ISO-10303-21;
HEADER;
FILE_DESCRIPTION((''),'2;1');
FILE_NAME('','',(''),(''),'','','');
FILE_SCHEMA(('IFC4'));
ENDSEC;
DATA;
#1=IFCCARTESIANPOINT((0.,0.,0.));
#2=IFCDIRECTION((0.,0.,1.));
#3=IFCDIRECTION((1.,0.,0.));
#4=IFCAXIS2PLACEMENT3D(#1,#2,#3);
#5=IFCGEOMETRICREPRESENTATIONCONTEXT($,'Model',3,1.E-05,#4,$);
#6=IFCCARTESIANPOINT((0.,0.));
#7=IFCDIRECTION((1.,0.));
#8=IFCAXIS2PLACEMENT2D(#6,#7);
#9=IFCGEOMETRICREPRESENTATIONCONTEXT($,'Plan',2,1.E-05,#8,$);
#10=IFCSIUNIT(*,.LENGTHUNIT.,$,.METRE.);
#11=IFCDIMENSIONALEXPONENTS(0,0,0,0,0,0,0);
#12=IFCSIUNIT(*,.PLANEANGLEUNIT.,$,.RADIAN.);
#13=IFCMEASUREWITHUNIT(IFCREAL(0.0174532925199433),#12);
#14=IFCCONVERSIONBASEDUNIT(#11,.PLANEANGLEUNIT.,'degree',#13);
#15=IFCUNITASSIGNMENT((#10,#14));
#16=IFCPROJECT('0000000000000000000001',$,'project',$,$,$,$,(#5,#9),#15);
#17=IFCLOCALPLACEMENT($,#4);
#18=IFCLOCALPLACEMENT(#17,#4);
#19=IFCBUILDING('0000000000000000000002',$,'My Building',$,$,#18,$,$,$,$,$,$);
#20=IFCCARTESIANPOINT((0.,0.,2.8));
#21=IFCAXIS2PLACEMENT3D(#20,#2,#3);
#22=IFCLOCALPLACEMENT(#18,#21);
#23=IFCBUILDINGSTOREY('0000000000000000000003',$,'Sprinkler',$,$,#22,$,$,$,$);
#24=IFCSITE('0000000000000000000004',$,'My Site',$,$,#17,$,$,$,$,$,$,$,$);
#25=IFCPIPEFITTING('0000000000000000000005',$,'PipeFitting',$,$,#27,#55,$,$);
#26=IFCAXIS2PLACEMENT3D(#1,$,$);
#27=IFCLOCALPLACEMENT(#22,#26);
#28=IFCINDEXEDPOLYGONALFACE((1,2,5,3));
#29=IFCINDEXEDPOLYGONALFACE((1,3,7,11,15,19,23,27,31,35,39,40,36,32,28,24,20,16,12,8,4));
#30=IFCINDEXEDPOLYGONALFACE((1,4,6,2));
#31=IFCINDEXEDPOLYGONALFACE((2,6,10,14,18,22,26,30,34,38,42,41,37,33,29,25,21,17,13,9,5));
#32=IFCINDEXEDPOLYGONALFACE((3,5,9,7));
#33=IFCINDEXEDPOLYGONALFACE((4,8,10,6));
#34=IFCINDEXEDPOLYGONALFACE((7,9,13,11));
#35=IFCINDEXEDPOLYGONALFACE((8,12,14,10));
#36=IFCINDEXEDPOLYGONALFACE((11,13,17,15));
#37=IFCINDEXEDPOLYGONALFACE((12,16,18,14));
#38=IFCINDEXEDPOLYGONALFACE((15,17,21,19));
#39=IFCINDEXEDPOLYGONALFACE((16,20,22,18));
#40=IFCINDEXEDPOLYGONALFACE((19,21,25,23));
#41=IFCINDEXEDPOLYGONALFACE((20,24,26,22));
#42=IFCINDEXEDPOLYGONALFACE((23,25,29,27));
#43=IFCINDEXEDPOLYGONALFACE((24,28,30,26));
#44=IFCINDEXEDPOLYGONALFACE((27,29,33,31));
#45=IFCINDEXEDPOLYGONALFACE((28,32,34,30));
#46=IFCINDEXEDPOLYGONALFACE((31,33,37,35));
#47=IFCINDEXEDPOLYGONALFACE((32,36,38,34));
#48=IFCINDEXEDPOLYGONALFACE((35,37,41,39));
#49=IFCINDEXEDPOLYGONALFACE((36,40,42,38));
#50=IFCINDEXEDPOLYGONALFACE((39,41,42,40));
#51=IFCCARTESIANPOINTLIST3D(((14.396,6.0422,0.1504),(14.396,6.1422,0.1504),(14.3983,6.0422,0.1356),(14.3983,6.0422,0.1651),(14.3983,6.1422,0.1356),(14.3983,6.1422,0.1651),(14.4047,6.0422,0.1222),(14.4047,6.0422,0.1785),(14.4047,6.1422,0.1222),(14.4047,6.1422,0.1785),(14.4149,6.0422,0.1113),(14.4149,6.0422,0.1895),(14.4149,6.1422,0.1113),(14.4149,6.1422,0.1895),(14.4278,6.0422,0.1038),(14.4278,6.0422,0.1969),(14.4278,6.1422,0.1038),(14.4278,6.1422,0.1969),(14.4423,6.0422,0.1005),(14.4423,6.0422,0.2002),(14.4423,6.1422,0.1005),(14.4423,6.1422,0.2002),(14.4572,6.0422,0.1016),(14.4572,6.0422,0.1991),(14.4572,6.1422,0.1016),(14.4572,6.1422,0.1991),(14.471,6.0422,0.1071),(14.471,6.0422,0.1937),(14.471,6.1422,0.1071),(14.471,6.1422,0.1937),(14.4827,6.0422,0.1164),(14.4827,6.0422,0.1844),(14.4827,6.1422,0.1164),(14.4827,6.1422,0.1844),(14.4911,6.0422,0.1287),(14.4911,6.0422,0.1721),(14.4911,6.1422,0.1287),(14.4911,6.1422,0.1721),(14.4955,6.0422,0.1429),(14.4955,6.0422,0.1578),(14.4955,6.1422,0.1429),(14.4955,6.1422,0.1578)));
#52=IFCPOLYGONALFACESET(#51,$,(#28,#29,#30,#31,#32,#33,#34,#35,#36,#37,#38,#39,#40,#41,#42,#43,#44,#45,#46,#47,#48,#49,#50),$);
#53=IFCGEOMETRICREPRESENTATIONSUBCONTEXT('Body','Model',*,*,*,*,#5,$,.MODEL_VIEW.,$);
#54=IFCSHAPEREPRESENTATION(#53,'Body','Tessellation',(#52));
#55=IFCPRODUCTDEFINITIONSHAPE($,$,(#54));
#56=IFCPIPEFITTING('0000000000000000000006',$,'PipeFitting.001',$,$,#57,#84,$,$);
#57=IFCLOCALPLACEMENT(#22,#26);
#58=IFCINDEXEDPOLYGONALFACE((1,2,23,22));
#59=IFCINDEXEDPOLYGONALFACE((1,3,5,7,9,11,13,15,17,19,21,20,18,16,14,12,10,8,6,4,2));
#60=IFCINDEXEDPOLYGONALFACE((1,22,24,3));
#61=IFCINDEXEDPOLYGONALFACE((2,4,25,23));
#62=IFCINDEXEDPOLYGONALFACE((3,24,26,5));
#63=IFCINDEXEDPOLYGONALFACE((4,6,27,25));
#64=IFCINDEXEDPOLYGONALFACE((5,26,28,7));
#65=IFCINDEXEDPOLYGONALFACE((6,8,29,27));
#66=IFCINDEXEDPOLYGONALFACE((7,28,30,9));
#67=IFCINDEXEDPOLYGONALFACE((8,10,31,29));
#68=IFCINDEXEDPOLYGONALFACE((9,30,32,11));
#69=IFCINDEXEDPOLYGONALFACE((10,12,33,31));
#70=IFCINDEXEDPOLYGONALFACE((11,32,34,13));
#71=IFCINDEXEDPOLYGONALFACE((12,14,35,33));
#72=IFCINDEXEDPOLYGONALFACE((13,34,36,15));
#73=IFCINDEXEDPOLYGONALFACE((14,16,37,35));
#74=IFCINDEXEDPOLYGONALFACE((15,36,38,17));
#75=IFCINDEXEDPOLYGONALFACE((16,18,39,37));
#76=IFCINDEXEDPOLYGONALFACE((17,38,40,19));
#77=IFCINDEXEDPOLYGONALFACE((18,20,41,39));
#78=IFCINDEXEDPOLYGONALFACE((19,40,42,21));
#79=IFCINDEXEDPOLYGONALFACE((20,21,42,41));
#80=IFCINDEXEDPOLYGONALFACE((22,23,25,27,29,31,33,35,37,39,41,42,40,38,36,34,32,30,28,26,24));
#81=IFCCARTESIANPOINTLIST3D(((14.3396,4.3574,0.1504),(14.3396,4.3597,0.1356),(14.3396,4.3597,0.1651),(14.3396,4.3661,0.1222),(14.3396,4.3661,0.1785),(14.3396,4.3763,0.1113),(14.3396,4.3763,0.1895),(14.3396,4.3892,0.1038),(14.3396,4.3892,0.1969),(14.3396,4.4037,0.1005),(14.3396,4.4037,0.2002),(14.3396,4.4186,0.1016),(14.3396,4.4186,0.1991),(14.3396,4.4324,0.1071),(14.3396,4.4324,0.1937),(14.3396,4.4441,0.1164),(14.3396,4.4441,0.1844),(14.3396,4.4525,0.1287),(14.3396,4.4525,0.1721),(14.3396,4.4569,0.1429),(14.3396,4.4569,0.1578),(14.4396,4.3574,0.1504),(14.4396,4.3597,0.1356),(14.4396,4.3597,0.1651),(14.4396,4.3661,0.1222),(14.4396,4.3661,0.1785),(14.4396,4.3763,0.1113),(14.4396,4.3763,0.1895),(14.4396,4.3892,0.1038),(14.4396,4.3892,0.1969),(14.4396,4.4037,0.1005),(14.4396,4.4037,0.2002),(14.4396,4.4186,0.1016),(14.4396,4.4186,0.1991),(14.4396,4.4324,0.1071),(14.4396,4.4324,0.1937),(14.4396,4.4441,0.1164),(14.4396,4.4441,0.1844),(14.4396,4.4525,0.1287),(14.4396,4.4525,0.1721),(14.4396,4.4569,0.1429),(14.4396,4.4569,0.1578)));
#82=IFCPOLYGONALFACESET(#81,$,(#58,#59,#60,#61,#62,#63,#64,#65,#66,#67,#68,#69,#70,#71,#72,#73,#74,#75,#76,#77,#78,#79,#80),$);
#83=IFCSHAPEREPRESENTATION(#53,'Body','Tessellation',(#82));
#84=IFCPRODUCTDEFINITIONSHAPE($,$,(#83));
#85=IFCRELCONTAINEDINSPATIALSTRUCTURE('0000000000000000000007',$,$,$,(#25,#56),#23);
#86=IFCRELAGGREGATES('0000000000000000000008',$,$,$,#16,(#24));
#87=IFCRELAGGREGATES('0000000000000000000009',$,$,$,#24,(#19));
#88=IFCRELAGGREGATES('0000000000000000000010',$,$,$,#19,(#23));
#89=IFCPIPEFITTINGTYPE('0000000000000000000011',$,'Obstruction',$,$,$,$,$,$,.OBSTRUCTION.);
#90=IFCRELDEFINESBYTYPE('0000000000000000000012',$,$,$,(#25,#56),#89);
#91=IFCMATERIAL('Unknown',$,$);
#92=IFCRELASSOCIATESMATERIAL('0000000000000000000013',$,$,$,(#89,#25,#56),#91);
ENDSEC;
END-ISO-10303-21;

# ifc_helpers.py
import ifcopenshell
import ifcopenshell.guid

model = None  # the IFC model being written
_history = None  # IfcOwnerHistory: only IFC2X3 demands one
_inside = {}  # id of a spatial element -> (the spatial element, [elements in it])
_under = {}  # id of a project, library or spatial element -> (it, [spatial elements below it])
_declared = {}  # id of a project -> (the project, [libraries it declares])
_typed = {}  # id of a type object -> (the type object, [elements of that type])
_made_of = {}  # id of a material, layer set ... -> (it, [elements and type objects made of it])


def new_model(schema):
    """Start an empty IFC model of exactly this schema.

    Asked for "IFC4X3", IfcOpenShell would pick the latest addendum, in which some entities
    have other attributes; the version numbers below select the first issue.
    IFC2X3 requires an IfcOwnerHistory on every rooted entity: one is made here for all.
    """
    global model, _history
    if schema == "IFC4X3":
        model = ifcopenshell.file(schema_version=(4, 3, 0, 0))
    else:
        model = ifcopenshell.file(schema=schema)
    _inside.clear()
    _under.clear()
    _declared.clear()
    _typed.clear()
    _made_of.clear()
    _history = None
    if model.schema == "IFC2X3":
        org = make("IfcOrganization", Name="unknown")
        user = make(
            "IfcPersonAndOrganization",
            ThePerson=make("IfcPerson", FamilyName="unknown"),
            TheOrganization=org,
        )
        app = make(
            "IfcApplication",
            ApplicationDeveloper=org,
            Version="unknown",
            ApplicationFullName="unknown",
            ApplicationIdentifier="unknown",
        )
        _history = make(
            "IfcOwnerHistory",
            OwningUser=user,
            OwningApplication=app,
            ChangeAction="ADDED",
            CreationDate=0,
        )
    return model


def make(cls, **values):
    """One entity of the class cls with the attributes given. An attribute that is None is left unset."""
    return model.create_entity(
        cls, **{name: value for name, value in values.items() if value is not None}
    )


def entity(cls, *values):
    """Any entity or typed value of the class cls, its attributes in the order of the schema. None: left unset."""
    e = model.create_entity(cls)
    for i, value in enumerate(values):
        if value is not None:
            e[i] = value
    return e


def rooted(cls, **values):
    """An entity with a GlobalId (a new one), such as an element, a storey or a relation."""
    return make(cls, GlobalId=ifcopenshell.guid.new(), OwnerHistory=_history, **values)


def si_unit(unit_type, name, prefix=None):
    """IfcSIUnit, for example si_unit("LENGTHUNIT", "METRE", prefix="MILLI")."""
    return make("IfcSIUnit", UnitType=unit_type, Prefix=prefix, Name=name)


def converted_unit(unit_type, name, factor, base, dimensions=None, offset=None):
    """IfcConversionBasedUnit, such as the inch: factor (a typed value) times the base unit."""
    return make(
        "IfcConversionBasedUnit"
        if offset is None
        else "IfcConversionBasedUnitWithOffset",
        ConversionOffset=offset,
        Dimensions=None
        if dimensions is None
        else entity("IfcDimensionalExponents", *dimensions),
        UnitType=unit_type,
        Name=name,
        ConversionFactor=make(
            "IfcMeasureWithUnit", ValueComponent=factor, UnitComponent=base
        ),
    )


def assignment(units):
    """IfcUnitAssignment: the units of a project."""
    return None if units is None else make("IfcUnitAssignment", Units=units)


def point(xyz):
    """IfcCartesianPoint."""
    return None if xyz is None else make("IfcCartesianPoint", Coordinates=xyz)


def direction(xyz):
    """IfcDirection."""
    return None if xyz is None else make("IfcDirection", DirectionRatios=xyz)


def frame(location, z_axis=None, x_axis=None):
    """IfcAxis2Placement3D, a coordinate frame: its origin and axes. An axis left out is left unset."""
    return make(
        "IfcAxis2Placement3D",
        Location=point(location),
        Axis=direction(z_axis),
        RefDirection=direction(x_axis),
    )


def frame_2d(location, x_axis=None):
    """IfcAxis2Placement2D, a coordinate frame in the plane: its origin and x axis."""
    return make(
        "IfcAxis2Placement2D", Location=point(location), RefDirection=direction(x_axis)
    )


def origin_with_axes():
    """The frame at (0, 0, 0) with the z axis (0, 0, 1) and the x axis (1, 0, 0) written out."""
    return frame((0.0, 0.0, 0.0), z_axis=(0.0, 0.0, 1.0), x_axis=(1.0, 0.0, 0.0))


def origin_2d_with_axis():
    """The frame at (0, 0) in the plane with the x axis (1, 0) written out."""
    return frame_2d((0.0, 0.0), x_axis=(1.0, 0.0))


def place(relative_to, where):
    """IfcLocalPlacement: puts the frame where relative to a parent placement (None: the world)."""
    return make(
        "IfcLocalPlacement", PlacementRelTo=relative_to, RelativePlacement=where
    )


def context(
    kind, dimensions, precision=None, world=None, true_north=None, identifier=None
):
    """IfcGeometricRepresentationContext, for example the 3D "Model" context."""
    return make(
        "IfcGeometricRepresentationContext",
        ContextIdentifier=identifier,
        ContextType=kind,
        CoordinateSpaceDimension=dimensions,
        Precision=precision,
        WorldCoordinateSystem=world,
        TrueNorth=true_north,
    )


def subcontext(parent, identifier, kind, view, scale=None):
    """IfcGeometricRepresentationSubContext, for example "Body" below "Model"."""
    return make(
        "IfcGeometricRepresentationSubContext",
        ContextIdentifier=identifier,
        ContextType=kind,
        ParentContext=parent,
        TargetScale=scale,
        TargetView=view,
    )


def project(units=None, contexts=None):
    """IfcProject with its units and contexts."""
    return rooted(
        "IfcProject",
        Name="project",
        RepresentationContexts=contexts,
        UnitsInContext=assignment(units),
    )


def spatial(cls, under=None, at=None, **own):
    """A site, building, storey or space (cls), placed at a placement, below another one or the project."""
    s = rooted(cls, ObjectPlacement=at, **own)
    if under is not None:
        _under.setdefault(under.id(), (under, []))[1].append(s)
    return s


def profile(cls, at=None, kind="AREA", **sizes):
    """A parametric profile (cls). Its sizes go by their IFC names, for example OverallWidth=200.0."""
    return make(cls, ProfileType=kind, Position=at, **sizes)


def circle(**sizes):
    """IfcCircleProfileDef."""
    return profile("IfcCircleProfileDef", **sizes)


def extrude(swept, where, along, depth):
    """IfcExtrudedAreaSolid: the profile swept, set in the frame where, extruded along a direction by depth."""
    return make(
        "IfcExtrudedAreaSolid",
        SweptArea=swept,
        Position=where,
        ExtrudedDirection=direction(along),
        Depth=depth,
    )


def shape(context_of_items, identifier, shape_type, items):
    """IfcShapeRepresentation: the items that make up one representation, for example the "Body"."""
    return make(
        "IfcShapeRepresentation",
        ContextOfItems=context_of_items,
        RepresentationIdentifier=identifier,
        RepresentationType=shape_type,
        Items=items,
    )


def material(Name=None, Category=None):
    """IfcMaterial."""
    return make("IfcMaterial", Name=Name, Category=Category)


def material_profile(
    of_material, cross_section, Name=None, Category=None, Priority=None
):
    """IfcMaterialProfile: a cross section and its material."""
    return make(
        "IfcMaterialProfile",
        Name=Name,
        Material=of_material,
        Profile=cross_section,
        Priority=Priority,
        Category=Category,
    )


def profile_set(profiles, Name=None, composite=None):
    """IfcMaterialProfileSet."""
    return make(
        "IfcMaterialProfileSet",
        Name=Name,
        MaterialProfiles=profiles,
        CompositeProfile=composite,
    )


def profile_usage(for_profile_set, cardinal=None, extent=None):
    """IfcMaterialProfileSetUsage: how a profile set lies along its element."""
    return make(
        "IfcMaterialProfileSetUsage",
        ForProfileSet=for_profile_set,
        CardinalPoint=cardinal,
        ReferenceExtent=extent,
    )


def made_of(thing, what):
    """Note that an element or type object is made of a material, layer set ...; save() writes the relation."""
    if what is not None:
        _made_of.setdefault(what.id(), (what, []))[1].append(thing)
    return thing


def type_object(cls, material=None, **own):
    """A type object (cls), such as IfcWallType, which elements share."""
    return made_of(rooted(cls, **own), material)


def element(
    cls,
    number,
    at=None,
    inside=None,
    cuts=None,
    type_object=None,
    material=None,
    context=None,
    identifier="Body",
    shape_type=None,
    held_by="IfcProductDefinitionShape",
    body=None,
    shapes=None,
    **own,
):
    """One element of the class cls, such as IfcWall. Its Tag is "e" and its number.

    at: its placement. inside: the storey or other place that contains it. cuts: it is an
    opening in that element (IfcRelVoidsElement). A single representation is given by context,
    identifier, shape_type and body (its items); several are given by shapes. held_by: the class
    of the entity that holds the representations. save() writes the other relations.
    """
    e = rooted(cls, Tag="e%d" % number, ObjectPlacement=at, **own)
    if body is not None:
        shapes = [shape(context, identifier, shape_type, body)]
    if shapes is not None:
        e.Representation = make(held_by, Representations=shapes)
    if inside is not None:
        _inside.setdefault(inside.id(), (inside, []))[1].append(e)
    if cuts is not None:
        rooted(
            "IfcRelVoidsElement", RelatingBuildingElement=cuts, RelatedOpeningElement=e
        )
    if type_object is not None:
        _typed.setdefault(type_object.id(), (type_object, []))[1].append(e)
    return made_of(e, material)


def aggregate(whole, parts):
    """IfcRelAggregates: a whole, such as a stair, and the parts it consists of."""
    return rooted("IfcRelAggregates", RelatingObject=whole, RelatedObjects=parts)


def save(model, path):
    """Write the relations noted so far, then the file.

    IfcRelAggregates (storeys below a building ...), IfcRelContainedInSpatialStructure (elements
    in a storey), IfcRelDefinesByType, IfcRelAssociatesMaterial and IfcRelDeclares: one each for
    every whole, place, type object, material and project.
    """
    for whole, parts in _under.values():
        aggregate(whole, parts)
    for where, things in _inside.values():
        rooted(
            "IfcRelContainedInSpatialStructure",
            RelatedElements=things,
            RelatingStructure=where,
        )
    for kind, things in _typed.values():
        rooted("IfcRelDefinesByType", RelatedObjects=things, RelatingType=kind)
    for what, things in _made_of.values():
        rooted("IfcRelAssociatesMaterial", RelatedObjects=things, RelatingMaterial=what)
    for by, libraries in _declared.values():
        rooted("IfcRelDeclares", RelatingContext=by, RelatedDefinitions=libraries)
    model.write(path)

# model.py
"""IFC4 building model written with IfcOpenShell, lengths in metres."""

from ifc_helpers import new_model, entity, si_unit, converted_unit, frame, origin_with_axes, origin_2d_with_axis, place, context, subcontext, project, spatial, circle, extrude, material, material_profile, profile_set, profile_usage, type_object, element, save


model = new_model("IFC4")

# Units and contexts
model_context = context("Model", 3, precision=1e-05, world=origin_with_axes())
plan_context = context("Plan", 2, precision=1e-05, world=origin_2d_with_axis())
body_context = subcontext(model_context, "Body", "Model", "MODEL_VIEW")
ifc_project = project(units=[si_unit("LENGTHUNIT", "METRE"), converted_unit("PLANEANGLEUNIT", "degree", entity("IfcReal", 0.0174532925199433), si_unit("PLANEANGLEUNIT", "RADIAN"), dimensions=[0, 0, 0, 0, 0, 0, 0])], contexts=[model_context, plan_context])

# Site, building, storey
site_placement = place(None, origin_with_axes())
site = spatial("IfcSite", under=ifc_project, at=site_placement, Name="My Site")
building_placement = place(site_placement, origin_with_axes())
building = spatial("IfcBuilding", under=site, at=building_placement, Name="My Building")
storey_placement = place(building_placement, frame((0.0, 0.0, 2.8), z_axis=(0.0, 0.0, 1.0), x_axis=(1.0, 0.0, 0.0)))
storey = spatial("IfcBuildingStorey", under=building, at=storey_placement, Name="Sprinkler")

# Shared definitions
ifc_material = material(Name="Unknown")

# Pipe fittings
ifc_material_profile_1 = material_profile(ifc_material, circle(Radius=0.05))
ifc_profile_set_1 = profile_set([ifc_material_profile_1])
pipe_fitting_type_1 = type_object("IfcPipeFittingType", Name="Obstruction", PredefinedType="OBSTRUCTION", material=ifc_profile_set_1)
ifc_profile_usage_1 = profile_usage(ifc_profile_set_1, cardinal=8)
pipe_fitting_1_placement = place(storey_placement, frame((14.446, 6.0422, 0.2004), z_axis=(0.0, 1.0, 0.0), x_axis=(-1.0, 0.0, 0.0)))
element("IfcPipeFitting", 1, at=pipe_fitting_1_placement, inside=storey, type_object=pipe_fitting_type_1, material=ifc_profile_usage_1, Name="PipeFitting", context=body_context, shape_type="SweptSolid", body=[
    extrude(circle(Radius=0.05), frame((0.0, -0.05, 0.0), z_axis=(0.0, 0.0, 1.0), x_axis=(1.0, 0.0, 0.0)), (0.0, 0.0, 1.0), 0.1),
])
ifc_profile_usage_2 = profile_usage(ifc_profile_set_1, cardinal=8)
pipe_fitting_2_placement = place(storey_placement, frame((14.4396, 4.4074, 0.2004), z_axis=(-1.0, 0.0, 0.0), x_axis=(0.0, -1.0, 0.0)))
element("IfcPipeFitting", 2, at=pipe_fitting_2_placement, inside=storey, type_object=pipe_fitting_type_1, material=ifc_profile_usage_2, Name="PipeFitting.001", context=body_context, shape_type="SweptSolid", body=[
    extrude(circle(Radius=0.05), frame((0.0, -0.05, 0.0), z_axis=(0.0, 0.0, 1.0), x_axis=(1.0, 0.0, 0.0)), (0.0, 0.0, 1.0), 0.1),
])

save(model, "model.ifc")
